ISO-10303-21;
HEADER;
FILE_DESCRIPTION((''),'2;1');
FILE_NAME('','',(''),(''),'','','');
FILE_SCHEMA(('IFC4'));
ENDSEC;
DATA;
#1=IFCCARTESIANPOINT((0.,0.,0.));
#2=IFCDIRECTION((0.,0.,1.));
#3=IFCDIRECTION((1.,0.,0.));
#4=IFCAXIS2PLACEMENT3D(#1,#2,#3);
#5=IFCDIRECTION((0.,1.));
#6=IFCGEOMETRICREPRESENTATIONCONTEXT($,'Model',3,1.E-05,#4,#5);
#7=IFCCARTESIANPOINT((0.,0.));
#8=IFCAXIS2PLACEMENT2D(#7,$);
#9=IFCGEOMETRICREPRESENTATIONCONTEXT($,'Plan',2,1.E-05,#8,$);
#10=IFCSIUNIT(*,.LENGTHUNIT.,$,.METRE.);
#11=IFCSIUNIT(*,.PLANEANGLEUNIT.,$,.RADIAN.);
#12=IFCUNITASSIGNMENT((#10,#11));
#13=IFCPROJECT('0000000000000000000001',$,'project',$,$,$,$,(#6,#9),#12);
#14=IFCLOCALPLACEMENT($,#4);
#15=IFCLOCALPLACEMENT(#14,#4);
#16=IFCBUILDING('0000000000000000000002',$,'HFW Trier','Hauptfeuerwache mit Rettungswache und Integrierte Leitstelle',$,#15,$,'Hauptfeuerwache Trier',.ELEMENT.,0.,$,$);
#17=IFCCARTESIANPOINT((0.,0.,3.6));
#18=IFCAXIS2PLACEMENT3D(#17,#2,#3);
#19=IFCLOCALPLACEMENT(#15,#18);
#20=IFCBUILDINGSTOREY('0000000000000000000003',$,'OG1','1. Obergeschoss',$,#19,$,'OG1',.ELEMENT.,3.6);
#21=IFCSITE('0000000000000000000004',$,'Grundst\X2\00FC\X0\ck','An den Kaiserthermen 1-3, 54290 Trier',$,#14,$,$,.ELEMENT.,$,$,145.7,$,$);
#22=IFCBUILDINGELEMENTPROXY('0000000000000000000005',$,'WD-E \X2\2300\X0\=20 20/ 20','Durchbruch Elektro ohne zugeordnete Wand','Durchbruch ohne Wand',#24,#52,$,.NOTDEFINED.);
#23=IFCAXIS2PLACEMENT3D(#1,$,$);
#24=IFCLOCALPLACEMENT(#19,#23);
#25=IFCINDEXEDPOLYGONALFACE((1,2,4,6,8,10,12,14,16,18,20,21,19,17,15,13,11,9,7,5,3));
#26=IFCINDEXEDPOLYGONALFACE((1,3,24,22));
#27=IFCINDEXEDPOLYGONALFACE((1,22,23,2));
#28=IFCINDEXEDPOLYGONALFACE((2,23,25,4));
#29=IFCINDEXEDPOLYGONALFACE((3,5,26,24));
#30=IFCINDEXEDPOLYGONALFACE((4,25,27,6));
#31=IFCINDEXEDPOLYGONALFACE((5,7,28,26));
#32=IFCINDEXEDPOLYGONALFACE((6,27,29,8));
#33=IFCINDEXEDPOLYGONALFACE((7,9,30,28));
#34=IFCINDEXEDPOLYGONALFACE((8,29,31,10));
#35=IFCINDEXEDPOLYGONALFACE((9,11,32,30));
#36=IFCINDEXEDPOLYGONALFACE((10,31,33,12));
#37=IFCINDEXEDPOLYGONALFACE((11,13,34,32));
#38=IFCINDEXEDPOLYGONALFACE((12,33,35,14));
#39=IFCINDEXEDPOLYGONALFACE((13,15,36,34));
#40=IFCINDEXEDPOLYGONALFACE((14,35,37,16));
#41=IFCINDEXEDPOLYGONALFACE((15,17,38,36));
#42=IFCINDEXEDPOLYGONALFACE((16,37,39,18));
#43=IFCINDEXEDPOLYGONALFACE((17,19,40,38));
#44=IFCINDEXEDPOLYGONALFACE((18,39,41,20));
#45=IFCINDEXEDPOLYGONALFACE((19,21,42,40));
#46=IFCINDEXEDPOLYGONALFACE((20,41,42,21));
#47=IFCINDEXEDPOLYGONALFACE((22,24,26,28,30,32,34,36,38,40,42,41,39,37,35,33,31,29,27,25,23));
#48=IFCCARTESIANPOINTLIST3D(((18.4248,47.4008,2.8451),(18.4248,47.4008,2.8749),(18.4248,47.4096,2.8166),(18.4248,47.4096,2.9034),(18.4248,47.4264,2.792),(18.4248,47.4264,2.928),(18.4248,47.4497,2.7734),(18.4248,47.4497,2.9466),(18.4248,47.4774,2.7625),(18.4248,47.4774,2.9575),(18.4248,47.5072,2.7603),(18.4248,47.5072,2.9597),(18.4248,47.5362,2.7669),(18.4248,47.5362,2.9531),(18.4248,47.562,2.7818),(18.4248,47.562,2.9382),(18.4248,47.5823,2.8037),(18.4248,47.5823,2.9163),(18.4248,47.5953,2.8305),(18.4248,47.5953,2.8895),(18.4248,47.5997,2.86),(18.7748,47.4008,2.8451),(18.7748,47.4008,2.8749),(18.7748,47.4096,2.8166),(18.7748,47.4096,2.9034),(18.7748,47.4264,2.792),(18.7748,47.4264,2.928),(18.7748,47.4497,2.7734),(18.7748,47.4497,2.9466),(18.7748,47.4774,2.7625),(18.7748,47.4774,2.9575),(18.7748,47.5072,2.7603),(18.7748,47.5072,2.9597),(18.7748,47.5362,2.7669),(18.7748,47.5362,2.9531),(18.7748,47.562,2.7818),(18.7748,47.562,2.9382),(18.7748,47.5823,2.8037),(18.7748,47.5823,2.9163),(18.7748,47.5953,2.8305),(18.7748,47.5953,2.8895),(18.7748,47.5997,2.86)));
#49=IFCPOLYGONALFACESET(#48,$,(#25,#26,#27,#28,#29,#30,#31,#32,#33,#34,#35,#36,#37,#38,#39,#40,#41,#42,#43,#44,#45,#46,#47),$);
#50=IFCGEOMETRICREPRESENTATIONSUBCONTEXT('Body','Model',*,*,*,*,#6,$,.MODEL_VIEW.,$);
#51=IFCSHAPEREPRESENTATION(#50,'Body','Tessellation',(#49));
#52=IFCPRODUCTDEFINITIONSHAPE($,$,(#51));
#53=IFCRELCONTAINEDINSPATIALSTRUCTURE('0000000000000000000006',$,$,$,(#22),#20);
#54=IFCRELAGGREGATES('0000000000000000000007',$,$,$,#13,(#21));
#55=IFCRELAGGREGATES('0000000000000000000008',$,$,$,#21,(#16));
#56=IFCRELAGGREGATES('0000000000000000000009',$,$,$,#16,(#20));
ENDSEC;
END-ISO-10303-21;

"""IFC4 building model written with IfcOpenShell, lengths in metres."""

from ifc_helpers import new_model, si_unit, direction, frame, origin_with_axes, origin_2d, place, context, subcontext, project, spatial, circle, extrude, element, save


model = new_model("IFC4")

# Units and contexts
model_context = context("Model", 3, precision=1e-05, world=origin_with_axes(), true_north=direction((0.0, 1.0)))
plan_context = context("Plan", 2, precision=1e-05, world=origin_2d())
body_context = subcontext(model_context, "Body", "Model", "MODEL_VIEW")
ifc_project = project(units=[si_unit("LENGTHUNIT", "METRE"), si_unit("PLANEANGLEUNIT", "RADIAN")], contexts=[model_context, plan_context])

# Site, building, storey
site_placement = place(None, origin_with_axes())
site = spatial("IfcSite", under=ifc_project, at=site_placement, Name="Grundstück", Description="An den Kaiserthermen 1-3, 54290 Trier", CompositionType="ELEMENT", RefElevation=145.7)
building_placement = place(site_placement, origin_with_axes())
building = spatial("IfcBuilding", under=site, at=building_placement, Name="HFW Trier", Description="Hauptfeuerwache mit Rettungswache und Integrierte Leitstelle", LongName="Hauptfeuerwache Trier", CompositionType="ELEMENT", ElevationOfRefHeight=0.0)
storey_placement = place(building_placement, frame((0.0, 0.0, 3.6), z_axis=(0.0, 0.0, 1.0), x_axis=(1.0, 0.0, 0.0)))
storey = spatial("IfcBuildingStorey", under=building, at=storey_placement, Name="OG1", Description="1. Obergeschoss", LongName="OG1", CompositionType="ELEMENT", Elevation=3.6)

# Building element proxy
for number, where, z_axis, x_axis, name in (
    (1, (18.5998, 47.4997, 2.76), (0.0, 0.0, 1.0), (0.0, 1.0, 0.0), "WD-E ⌀=20 20/ 20"),
):
    element("IfcBuildingElementProxy", number, at=place(storey_placement, frame(where, z_axis=z_axis, x_axis=x_axis)), inside=storey, Name=name, Description="Durchbruch Elektro ohne zugeordnete Wand", ObjectType="Durchbruch ohne Wand", PredefinedType="NOTDEFINED", context=body_context, shape_type="SweptSolid", body=[
        extrude(circle(Radius=0.1, at=origin_2d()), frame((0.0, -0.175, 0.1), z_axis=(0.0, 1.0, 0.0), x_axis=(1.0, 0.0, 0.0)), (0.0, 0.0, 1.0), 0.35),
    ])

save(model, "model.ifc")
